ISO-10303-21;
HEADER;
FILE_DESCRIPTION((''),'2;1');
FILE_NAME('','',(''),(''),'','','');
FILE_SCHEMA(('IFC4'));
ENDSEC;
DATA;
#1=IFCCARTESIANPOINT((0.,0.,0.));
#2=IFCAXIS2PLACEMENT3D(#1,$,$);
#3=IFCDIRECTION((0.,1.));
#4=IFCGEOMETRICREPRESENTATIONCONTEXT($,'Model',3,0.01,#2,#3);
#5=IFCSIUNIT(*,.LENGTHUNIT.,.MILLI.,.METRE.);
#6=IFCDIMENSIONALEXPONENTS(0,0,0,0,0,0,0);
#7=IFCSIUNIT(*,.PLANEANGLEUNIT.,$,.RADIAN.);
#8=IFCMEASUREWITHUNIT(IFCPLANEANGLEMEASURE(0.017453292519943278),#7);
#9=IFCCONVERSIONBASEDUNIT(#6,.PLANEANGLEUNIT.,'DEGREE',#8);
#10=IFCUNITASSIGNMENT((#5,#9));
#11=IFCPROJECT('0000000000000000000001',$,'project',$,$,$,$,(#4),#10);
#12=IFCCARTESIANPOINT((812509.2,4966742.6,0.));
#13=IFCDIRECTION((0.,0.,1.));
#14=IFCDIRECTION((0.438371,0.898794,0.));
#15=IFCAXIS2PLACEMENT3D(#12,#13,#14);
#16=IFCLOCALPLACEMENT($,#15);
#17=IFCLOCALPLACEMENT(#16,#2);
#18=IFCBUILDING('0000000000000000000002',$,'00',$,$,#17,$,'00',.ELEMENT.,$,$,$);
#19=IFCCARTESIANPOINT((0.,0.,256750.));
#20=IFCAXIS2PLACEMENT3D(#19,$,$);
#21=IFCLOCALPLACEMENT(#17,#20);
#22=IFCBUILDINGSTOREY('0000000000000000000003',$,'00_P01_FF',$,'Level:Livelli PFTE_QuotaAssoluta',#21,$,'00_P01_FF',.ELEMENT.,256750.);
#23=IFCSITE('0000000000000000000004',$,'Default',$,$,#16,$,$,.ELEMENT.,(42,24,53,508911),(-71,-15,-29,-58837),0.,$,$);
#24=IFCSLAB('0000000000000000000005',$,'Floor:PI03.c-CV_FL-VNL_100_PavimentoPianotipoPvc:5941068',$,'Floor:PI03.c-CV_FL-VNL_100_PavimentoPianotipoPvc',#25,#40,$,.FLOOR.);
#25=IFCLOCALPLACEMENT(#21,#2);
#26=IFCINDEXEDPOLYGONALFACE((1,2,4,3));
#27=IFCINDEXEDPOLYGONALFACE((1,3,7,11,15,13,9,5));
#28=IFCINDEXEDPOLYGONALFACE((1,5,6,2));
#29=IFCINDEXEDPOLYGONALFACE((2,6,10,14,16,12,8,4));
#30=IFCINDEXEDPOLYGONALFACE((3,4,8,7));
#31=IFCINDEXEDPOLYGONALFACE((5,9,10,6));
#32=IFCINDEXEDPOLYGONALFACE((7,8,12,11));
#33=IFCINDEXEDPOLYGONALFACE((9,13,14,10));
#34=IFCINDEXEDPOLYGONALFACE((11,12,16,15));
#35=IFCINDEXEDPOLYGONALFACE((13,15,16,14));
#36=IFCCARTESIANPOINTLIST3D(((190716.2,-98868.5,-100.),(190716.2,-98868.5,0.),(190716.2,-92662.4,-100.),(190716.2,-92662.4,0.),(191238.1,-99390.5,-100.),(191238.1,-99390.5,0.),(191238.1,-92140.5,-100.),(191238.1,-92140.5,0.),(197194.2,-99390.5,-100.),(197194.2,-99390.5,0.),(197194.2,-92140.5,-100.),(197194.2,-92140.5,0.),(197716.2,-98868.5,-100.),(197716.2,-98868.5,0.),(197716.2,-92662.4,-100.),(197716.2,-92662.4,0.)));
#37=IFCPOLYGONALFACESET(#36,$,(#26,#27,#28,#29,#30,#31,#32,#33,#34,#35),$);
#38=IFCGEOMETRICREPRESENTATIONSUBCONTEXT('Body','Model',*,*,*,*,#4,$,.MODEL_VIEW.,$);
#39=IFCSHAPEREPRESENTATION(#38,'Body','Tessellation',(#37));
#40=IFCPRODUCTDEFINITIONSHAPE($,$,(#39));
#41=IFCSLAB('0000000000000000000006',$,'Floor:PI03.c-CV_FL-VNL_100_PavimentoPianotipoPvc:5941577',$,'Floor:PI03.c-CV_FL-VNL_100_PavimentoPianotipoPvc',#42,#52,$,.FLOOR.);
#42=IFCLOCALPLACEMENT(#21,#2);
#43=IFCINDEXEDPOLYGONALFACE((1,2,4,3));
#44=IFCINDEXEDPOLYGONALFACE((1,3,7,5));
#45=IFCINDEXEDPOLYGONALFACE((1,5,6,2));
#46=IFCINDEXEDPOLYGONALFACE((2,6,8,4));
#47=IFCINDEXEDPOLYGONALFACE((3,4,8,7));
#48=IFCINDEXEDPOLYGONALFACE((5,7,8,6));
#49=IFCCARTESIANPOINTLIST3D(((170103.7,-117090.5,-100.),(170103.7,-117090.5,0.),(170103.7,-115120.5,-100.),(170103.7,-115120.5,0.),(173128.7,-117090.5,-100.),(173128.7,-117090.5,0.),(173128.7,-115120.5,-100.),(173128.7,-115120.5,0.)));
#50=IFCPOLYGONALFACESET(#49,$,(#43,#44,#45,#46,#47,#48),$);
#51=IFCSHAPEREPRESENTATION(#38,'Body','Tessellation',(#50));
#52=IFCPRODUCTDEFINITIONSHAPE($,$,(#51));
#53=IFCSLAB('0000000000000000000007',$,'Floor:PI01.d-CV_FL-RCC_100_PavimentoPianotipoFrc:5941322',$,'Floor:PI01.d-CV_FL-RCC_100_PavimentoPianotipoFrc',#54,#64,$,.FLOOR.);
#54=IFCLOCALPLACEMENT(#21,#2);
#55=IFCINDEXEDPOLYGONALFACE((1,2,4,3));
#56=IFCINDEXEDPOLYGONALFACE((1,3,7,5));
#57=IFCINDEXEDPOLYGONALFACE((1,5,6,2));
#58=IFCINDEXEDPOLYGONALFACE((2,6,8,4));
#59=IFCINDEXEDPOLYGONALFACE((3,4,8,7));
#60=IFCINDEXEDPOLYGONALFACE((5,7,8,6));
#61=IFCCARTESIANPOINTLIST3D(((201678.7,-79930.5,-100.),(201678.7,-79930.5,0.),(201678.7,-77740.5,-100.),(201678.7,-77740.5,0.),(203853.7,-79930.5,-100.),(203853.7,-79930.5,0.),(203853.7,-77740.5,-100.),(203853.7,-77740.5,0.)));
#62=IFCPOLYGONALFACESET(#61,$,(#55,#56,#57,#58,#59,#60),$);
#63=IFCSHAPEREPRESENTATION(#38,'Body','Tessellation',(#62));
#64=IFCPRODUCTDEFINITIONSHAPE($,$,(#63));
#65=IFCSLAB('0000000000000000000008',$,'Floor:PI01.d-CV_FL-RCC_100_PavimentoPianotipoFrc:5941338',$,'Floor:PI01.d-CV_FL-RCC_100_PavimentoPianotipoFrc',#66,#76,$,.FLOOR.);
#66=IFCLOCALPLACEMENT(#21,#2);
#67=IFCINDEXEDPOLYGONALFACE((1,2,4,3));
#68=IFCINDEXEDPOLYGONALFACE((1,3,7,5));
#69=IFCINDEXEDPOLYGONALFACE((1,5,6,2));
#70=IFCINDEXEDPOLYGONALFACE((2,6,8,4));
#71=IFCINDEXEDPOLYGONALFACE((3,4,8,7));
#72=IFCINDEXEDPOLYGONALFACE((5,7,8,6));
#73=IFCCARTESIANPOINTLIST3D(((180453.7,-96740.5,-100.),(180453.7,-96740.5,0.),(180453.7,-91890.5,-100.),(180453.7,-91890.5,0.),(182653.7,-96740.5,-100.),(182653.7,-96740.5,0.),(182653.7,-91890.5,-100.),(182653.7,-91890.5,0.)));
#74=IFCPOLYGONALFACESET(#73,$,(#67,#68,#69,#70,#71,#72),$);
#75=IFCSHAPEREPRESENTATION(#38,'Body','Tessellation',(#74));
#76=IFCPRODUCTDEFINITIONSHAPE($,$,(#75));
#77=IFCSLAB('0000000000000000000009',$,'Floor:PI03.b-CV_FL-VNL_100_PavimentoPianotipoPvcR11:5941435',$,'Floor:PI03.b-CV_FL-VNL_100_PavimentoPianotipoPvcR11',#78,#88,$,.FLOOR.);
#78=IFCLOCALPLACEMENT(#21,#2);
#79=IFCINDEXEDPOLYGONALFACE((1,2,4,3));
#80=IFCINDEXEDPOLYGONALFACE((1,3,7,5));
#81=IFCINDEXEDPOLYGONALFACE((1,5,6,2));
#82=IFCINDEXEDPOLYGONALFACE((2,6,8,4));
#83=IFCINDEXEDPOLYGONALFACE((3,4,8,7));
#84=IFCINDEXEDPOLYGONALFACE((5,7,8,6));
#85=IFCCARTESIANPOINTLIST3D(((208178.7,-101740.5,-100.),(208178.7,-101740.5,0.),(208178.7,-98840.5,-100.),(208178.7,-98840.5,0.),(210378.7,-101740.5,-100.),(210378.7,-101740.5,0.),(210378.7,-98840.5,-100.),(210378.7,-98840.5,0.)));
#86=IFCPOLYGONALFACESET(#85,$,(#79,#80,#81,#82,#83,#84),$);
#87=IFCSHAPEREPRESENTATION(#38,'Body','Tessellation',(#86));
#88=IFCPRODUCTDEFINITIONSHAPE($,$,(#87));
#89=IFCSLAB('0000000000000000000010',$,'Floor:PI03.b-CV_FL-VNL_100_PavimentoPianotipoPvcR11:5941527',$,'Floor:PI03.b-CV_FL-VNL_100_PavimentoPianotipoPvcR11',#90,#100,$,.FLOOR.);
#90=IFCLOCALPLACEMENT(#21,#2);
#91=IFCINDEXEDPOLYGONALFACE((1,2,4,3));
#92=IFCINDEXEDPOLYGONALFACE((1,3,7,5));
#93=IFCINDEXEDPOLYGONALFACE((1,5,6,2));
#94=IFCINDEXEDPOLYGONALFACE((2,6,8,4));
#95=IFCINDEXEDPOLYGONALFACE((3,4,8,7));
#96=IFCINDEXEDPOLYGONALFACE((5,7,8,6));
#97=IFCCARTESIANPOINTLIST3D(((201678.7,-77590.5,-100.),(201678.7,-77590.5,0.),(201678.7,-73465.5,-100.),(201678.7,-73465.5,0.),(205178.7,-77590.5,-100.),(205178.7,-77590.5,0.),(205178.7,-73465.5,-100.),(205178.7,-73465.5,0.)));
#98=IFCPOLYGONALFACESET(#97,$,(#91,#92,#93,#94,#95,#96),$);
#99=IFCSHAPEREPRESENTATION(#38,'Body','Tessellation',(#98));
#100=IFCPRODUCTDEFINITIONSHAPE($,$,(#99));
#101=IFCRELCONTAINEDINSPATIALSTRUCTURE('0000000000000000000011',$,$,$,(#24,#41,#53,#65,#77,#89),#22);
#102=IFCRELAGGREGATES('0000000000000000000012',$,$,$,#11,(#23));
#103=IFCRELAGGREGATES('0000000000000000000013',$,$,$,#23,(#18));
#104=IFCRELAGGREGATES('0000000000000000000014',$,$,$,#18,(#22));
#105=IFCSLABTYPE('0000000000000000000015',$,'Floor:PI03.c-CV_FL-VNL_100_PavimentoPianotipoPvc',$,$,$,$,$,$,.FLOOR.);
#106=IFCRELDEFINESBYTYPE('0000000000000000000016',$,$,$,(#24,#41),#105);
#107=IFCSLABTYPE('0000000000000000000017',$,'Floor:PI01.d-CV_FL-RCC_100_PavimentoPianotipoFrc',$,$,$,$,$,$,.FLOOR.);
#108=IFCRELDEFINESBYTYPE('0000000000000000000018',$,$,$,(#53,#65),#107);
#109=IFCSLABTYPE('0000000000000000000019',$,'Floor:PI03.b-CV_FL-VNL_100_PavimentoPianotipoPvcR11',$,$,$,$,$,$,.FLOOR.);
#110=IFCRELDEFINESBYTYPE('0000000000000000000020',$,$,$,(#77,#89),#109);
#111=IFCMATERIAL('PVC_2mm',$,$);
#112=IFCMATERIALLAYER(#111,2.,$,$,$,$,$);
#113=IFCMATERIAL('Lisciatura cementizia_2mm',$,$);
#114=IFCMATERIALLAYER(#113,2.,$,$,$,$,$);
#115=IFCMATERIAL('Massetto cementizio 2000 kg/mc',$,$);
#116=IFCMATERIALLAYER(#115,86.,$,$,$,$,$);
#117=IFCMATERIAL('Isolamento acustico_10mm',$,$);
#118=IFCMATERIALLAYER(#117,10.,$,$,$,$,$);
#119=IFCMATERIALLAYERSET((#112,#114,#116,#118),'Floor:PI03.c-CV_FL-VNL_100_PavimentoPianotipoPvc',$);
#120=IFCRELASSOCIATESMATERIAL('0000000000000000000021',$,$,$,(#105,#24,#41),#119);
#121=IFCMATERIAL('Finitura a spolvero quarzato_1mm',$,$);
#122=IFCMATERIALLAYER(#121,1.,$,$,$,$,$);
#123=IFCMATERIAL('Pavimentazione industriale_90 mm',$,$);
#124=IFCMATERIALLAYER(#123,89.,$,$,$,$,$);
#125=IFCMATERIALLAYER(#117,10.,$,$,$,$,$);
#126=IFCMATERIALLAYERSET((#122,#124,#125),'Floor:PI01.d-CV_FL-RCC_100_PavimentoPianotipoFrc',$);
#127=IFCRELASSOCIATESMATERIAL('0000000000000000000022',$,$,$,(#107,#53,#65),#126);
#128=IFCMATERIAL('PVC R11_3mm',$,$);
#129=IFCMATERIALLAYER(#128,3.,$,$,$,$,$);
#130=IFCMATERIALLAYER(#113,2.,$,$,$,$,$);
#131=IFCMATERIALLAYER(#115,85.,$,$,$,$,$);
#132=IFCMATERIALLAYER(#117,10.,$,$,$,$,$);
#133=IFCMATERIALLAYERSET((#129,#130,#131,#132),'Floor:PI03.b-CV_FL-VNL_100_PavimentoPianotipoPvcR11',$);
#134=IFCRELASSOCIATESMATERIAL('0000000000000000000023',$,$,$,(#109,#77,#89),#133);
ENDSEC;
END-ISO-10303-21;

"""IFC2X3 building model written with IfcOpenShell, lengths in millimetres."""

from ifc_helpers import new_model, entity, si_unit, converted_unit, direction, frame, frame_2d, origin, place, context, subcontext, project, spatial, polyline, rectangle, outline, extrude, material, layer, layer_set, layer_usage, type_object, element, save


model = new_model("IFC2X3")

# Units and contexts
model_context = context("Model", 3, precision=0.01, world=origin(), true_north=direction((0.0, 1.0)))
body_context = subcontext(model_context, "Body", "Model", "MODEL_VIEW")
ifc_project = project(units=[si_unit("LENGTHUNIT", "METRE", prefix="MILLI"), converted_unit("PLANEANGLEUNIT", "DEGREE", entity("IfcPlaneAngleMeasure", 0.017453292519943278), si_unit("PLANEANGLEUNIT", "RADIAN"), dimensions=[0, 0, 0, 0, 0, 0, 0])], contexts=[model_context])

# Site, building, storey
site_placement = place(None, frame((812509.2, 4966742.6, 0.0), z_axis=(0.0, 0.0, 1.0), x_axis=(0.438371, 0.898794, 0.0)))
site = spatial("IfcSite", under=ifc_project, at=site_placement, Name="Default", CompositionType="ELEMENT", RefLatitude=(42, 24, 53, 508911), RefLongitude=(-71, -15, -29, -58837), RefElevation=0.0)
building_placement = place(site_placement, origin())
building = spatial("IfcBuilding", under=site, at=building_placement, Name="00", LongName="00", CompositionType="ELEMENT")
storey_placement = place(building_placement, frame((0.0, 0.0, 256750.0)))
storey = spatial("IfcBuildingStorey", under=building, at=storey_placement, Name="00_P01_FF", ObjectType="Level:Livelli PFTE_QuotaAssoluta", LongName="00_P01_FF", CompositionType="ELEMENT", Elevation=256750.0)

# Slabs
ifc_material_1 = material(Name="PVC_2mm")
ifc_layer_1 = layer(ifc_material_1, 2.0)
ifc_material_2 = material(Name="Lisciatura cementizia_2mm")
ifc_layer_2 = layer(ifc_material_2, 2.0)
ifc_material_3 = material(Name="Massetto cementizio 2000 kg/mc")
ifc_layer_3 = layer(ifc_material_3, 86.0)
ifc_material_4 = material(Name="Isolamento acustico_10mm")
ifc_layer_4 = layer(ifc_material_4, 10.0)
ifc_layer_set_1 = layer_set([ifc_layer_1, ifc_layer_2, ifc_layer_3, ifc_layer_4], Name="Floor:PI03.c-CV_FL-VNL_100_PavimentoPianotipoPvc")
slab_type_1 = type_object("IfcSlabType", Name="Floor:PI03.c-CV_FL-VNL_100_PavimentoPianotipoPvc", PredefinedType="FLOOR", material=ifc_layer_set_1)
ifc_layer_usage_1 = layer_usage(ifc_layer_set_1, "AXIS3", "POSITIVE", 0.0)
slab_1_placement = place(storey_placement, origin())
element("IfcSlab", 1, at=slab_1_placement, inside=storey, type_object=slab_type_1, material=ifc_layer_usage_1, Name="Floor:PI03.c-CV_FL-VNL_100_PavimentoPianotipoPvc:5941068", ObjectType="Floor:PI03.c-CV_FL-VNL_100_PavimentoPianotipoPvc", PredefinedType="FLOOR", context=body_context, shape_type="SweptSolid", body=[
    extrude(outline(polyline([(-2978.0, -3625.0), (2978.0, -3625.0), (3500.0, -3103.0), (3500.0, 3103.0), (2978.0, 3625.0), (-2978.0, 3625.0), (-3500.0, 3103.0), (-3500.0, -3103.0), (-2978.0, -3625.0)])), frame((194216.2, -95765.5, 0.0), z_axis=(0.0, 0.0, -1.0), x_axis=(1.0, 0.0, 0.0)), (0.0, 0.0, 1.0), 100.0),
])
ifc_layer_usage_2 = layer_usage(ifc_layer_set_1, "AXIS3", "POSITIVE", 0.0)
slab_2_placement = place(storey_placement, origin())
element("IfcSlab", 2, at=slab_2_placement, inside=storey, type_object=slab_type_1, material=ifc_layer_usage_2, Name="Floor:PI03.c-CV_FL-VNL_100_PavimentoPianotipoPvc:5941577", ObjectType="Floor:PI03.c-CV_FL-VNL_100_PavimentoPianotipoPvc", PredefinedType="FLOOR", context=body_context, shape_type="SweptSolid", body=[
    extrude(rectangle(XDim=1970.0, YDim=3025.0, at=frame_2d((0.0, 0.0), x_axis=(1.0, 0.0))), frame((171616.2, -116105.5, 0.0), z_axis=(0.0, 0.0, -1.0), x_axis=(0.0, 1.0, 0.0)), (0.0, 0.0, 1.0), 100.0),
])
ifc_material_5 = material(Name="Finitura a spolvero quarzato_1mm")
ifc_layer_5 = layer(ifc_material_5, 1.0)
ifc_material_6 = material(Name="Pavimentazione industriale_90 mm")
ifc_layer_6 = layer(ifc_material_6, 89.0)
ifc_layer_7 = layer(ifc_material_4, 10.0)
ifc_layer_set_2 = layer_set([ifc_layer_5, ifc_layer_6, ifc_layer_7], Name="Floor:PI01.d-CV_FL-RCC_100_PavimentoPianotipoFrc")
ifc_layer_usage_3 = layer_usage(ifc_layer_set_2, "AXIS3", "POSITIVE", 0.0)
slab_type_2 = type_object("IfcSlabType", Name="Floor:PI01.d-CV_FL-RCC_100_PavimentoPianotipoFrc", PredefinedType="FLOOR", material=ifc_layer_set_2)
slab_3_placement = place(storey_placement, origin())
element("IfcSlab", 3, at=slab_3_placement, inside=storey, type_object=slab_type_2, material=ifc_layer_usage_3, Name="Floor:PI01.d-CV_FL-RCC_100_PavimentoPianotipoFrc:5941322", ObjectType="Floor:PI01.d-CV_FL-RCC_100_PavimentoPianotipoFrc", PredefinedType="FLOOR", context=body_context, shape_type="SweptSolid", body=[
    extrude(rectangle(XDim=2190.0, YDim=2175.0, at=frame_2d((0.0, 0.0), x_axis=(1.0, 0.0))), frame((202766.2, -78835.5, 0.0), z_axis=(0.0, 0.0, -1.0), x_axis=(0.0, 1.0, 0.0)), (0.0, 0.0, 1.0), 100.0),
])
ifc_layer_usage_4 = layer_usage(ifc_layer_set_2, "AXIS3", "POSITIVE", 0.0)
slab_4_placement = place(storey_placement, origin())
element("IfcSlab", 4, at=slab_4_placement, inside=storey, type_object=slab_type_2, material=ifc_layer_usage_4, Name="Floor:PI01.d-CV_FL-RCC_100_PavimentoPianotipoFrc:5941338", ObjectType="Floor:PI01.d-CV_FL-RCC_100_PavimentoPianotipoFrc", PredefinedType="FLOOR", context=body_context, shape_type="SweptSolid", body=[
    extrude(rectangle(XDim=4850.0, YDim=2200.0, at=frame_2d((0.0, 0.0), x_axis=(1.0, 0.0))), frame((181553.7, -94315.5, 0.0), z_axis=(0.0, 0.0, -1.0), x_axis=(0.0, 1.0, 0.0)), (0.0, 0.0, 1.0), 100.0),
])
ifc_material_7 = material(Name="PVC R11_3mm")
ifc_layer_8 = layer(ifc_material_7, 3.0)
ifc_layer_9 = layer(ifc_material_2, 2.0)
ifc_layer_10 = layer(ifc_material_3, 85.0)
ifc_layer_11 = layer(ifc_material_4, 10.0)
ifc_layer_set_3 = layer_set([ifc_layer_8, ifc_layer_9, ifc_layer_10, ifc_layer_11], Name="Floor:PI03.b-CV_FL-VNL_100_PavimentoPianotipoPvcR11")
slab_type_3 = type_object("IfcSlabType", Name="Floor:PI03.b-CV_FL-VNL_100_PavimentoPianotipoPvcR11", PredefinedType="FLOOR", material=ifc_layer_set_3)
ifc_layer_usage_5 = layer_usage(ifc_layer_set_3, "AXIS3", "POSITIVE", 0.0)
slab_5_placement = place(storey_placement, origin())
element("IfcSlab", 5, at=slab_5_placement, inside=storey, type_object=slab_type_3, material=ifc_layer_usage_5, Name="Floor:PI03.b-CV_FL-VNL_100_PavimentoPianotipoPvcR11:5941435", ObjectType="Floor:PI03.b-CV_FL-VNL_100_PavimentoPianotipoPvcR11", PredefinedType="FLOOR", context=body_context, shape_type="SweptSolid", body=[
    extrude(rectangle(XDim=2200.0, YDim=2900.0, at=frame_2d((0.0, 0.0), x_axis=(1.0, 0.0))), frame((209278.7, -100290.5, 0.0), z_axis=(0.0, 0.0, -1.0), x_axis=(1.0, 0.0, 0.0)), (0.0, 0.0, 1.0), 100.0),
])
ifc_layer_usage_6 = layer_usage(ifc_layer_set_3, "AXIS3", "POSITIVE", 0.0)
slab_6_placement = place(storey_placement, origin())
element("IfcSlab", 6, at=slab_6_placement, inside=storey, type_object=slab_type_3, material=ifc_layer_usage_6, Name="Floor:PI03.b-CV_FL-VNL_100_PavimentoPianotipoPvcR11:5941527", ObjectType="Floor:PI03.b-CV_FL-VNL_100_PavimentoPianotipoPvcR11", PredefinedType="FLOOR", context=body_context, shape_type="SweptSolid", body=[
    extrude(rectangle(XDim=4125.0, YDim=3500.0, at=frame_2d((0.0, 0.0), x_axis=(1.0, 0.0))), frame((203428.7, -75528.0, 0.0), z_axis=(0.0, 0.0, -1.0), x_axis=(0.0, 1.0, 0.0)), (0.0, 0.0, 1.0), 100.0),
])

save(model, "model.ifc")
